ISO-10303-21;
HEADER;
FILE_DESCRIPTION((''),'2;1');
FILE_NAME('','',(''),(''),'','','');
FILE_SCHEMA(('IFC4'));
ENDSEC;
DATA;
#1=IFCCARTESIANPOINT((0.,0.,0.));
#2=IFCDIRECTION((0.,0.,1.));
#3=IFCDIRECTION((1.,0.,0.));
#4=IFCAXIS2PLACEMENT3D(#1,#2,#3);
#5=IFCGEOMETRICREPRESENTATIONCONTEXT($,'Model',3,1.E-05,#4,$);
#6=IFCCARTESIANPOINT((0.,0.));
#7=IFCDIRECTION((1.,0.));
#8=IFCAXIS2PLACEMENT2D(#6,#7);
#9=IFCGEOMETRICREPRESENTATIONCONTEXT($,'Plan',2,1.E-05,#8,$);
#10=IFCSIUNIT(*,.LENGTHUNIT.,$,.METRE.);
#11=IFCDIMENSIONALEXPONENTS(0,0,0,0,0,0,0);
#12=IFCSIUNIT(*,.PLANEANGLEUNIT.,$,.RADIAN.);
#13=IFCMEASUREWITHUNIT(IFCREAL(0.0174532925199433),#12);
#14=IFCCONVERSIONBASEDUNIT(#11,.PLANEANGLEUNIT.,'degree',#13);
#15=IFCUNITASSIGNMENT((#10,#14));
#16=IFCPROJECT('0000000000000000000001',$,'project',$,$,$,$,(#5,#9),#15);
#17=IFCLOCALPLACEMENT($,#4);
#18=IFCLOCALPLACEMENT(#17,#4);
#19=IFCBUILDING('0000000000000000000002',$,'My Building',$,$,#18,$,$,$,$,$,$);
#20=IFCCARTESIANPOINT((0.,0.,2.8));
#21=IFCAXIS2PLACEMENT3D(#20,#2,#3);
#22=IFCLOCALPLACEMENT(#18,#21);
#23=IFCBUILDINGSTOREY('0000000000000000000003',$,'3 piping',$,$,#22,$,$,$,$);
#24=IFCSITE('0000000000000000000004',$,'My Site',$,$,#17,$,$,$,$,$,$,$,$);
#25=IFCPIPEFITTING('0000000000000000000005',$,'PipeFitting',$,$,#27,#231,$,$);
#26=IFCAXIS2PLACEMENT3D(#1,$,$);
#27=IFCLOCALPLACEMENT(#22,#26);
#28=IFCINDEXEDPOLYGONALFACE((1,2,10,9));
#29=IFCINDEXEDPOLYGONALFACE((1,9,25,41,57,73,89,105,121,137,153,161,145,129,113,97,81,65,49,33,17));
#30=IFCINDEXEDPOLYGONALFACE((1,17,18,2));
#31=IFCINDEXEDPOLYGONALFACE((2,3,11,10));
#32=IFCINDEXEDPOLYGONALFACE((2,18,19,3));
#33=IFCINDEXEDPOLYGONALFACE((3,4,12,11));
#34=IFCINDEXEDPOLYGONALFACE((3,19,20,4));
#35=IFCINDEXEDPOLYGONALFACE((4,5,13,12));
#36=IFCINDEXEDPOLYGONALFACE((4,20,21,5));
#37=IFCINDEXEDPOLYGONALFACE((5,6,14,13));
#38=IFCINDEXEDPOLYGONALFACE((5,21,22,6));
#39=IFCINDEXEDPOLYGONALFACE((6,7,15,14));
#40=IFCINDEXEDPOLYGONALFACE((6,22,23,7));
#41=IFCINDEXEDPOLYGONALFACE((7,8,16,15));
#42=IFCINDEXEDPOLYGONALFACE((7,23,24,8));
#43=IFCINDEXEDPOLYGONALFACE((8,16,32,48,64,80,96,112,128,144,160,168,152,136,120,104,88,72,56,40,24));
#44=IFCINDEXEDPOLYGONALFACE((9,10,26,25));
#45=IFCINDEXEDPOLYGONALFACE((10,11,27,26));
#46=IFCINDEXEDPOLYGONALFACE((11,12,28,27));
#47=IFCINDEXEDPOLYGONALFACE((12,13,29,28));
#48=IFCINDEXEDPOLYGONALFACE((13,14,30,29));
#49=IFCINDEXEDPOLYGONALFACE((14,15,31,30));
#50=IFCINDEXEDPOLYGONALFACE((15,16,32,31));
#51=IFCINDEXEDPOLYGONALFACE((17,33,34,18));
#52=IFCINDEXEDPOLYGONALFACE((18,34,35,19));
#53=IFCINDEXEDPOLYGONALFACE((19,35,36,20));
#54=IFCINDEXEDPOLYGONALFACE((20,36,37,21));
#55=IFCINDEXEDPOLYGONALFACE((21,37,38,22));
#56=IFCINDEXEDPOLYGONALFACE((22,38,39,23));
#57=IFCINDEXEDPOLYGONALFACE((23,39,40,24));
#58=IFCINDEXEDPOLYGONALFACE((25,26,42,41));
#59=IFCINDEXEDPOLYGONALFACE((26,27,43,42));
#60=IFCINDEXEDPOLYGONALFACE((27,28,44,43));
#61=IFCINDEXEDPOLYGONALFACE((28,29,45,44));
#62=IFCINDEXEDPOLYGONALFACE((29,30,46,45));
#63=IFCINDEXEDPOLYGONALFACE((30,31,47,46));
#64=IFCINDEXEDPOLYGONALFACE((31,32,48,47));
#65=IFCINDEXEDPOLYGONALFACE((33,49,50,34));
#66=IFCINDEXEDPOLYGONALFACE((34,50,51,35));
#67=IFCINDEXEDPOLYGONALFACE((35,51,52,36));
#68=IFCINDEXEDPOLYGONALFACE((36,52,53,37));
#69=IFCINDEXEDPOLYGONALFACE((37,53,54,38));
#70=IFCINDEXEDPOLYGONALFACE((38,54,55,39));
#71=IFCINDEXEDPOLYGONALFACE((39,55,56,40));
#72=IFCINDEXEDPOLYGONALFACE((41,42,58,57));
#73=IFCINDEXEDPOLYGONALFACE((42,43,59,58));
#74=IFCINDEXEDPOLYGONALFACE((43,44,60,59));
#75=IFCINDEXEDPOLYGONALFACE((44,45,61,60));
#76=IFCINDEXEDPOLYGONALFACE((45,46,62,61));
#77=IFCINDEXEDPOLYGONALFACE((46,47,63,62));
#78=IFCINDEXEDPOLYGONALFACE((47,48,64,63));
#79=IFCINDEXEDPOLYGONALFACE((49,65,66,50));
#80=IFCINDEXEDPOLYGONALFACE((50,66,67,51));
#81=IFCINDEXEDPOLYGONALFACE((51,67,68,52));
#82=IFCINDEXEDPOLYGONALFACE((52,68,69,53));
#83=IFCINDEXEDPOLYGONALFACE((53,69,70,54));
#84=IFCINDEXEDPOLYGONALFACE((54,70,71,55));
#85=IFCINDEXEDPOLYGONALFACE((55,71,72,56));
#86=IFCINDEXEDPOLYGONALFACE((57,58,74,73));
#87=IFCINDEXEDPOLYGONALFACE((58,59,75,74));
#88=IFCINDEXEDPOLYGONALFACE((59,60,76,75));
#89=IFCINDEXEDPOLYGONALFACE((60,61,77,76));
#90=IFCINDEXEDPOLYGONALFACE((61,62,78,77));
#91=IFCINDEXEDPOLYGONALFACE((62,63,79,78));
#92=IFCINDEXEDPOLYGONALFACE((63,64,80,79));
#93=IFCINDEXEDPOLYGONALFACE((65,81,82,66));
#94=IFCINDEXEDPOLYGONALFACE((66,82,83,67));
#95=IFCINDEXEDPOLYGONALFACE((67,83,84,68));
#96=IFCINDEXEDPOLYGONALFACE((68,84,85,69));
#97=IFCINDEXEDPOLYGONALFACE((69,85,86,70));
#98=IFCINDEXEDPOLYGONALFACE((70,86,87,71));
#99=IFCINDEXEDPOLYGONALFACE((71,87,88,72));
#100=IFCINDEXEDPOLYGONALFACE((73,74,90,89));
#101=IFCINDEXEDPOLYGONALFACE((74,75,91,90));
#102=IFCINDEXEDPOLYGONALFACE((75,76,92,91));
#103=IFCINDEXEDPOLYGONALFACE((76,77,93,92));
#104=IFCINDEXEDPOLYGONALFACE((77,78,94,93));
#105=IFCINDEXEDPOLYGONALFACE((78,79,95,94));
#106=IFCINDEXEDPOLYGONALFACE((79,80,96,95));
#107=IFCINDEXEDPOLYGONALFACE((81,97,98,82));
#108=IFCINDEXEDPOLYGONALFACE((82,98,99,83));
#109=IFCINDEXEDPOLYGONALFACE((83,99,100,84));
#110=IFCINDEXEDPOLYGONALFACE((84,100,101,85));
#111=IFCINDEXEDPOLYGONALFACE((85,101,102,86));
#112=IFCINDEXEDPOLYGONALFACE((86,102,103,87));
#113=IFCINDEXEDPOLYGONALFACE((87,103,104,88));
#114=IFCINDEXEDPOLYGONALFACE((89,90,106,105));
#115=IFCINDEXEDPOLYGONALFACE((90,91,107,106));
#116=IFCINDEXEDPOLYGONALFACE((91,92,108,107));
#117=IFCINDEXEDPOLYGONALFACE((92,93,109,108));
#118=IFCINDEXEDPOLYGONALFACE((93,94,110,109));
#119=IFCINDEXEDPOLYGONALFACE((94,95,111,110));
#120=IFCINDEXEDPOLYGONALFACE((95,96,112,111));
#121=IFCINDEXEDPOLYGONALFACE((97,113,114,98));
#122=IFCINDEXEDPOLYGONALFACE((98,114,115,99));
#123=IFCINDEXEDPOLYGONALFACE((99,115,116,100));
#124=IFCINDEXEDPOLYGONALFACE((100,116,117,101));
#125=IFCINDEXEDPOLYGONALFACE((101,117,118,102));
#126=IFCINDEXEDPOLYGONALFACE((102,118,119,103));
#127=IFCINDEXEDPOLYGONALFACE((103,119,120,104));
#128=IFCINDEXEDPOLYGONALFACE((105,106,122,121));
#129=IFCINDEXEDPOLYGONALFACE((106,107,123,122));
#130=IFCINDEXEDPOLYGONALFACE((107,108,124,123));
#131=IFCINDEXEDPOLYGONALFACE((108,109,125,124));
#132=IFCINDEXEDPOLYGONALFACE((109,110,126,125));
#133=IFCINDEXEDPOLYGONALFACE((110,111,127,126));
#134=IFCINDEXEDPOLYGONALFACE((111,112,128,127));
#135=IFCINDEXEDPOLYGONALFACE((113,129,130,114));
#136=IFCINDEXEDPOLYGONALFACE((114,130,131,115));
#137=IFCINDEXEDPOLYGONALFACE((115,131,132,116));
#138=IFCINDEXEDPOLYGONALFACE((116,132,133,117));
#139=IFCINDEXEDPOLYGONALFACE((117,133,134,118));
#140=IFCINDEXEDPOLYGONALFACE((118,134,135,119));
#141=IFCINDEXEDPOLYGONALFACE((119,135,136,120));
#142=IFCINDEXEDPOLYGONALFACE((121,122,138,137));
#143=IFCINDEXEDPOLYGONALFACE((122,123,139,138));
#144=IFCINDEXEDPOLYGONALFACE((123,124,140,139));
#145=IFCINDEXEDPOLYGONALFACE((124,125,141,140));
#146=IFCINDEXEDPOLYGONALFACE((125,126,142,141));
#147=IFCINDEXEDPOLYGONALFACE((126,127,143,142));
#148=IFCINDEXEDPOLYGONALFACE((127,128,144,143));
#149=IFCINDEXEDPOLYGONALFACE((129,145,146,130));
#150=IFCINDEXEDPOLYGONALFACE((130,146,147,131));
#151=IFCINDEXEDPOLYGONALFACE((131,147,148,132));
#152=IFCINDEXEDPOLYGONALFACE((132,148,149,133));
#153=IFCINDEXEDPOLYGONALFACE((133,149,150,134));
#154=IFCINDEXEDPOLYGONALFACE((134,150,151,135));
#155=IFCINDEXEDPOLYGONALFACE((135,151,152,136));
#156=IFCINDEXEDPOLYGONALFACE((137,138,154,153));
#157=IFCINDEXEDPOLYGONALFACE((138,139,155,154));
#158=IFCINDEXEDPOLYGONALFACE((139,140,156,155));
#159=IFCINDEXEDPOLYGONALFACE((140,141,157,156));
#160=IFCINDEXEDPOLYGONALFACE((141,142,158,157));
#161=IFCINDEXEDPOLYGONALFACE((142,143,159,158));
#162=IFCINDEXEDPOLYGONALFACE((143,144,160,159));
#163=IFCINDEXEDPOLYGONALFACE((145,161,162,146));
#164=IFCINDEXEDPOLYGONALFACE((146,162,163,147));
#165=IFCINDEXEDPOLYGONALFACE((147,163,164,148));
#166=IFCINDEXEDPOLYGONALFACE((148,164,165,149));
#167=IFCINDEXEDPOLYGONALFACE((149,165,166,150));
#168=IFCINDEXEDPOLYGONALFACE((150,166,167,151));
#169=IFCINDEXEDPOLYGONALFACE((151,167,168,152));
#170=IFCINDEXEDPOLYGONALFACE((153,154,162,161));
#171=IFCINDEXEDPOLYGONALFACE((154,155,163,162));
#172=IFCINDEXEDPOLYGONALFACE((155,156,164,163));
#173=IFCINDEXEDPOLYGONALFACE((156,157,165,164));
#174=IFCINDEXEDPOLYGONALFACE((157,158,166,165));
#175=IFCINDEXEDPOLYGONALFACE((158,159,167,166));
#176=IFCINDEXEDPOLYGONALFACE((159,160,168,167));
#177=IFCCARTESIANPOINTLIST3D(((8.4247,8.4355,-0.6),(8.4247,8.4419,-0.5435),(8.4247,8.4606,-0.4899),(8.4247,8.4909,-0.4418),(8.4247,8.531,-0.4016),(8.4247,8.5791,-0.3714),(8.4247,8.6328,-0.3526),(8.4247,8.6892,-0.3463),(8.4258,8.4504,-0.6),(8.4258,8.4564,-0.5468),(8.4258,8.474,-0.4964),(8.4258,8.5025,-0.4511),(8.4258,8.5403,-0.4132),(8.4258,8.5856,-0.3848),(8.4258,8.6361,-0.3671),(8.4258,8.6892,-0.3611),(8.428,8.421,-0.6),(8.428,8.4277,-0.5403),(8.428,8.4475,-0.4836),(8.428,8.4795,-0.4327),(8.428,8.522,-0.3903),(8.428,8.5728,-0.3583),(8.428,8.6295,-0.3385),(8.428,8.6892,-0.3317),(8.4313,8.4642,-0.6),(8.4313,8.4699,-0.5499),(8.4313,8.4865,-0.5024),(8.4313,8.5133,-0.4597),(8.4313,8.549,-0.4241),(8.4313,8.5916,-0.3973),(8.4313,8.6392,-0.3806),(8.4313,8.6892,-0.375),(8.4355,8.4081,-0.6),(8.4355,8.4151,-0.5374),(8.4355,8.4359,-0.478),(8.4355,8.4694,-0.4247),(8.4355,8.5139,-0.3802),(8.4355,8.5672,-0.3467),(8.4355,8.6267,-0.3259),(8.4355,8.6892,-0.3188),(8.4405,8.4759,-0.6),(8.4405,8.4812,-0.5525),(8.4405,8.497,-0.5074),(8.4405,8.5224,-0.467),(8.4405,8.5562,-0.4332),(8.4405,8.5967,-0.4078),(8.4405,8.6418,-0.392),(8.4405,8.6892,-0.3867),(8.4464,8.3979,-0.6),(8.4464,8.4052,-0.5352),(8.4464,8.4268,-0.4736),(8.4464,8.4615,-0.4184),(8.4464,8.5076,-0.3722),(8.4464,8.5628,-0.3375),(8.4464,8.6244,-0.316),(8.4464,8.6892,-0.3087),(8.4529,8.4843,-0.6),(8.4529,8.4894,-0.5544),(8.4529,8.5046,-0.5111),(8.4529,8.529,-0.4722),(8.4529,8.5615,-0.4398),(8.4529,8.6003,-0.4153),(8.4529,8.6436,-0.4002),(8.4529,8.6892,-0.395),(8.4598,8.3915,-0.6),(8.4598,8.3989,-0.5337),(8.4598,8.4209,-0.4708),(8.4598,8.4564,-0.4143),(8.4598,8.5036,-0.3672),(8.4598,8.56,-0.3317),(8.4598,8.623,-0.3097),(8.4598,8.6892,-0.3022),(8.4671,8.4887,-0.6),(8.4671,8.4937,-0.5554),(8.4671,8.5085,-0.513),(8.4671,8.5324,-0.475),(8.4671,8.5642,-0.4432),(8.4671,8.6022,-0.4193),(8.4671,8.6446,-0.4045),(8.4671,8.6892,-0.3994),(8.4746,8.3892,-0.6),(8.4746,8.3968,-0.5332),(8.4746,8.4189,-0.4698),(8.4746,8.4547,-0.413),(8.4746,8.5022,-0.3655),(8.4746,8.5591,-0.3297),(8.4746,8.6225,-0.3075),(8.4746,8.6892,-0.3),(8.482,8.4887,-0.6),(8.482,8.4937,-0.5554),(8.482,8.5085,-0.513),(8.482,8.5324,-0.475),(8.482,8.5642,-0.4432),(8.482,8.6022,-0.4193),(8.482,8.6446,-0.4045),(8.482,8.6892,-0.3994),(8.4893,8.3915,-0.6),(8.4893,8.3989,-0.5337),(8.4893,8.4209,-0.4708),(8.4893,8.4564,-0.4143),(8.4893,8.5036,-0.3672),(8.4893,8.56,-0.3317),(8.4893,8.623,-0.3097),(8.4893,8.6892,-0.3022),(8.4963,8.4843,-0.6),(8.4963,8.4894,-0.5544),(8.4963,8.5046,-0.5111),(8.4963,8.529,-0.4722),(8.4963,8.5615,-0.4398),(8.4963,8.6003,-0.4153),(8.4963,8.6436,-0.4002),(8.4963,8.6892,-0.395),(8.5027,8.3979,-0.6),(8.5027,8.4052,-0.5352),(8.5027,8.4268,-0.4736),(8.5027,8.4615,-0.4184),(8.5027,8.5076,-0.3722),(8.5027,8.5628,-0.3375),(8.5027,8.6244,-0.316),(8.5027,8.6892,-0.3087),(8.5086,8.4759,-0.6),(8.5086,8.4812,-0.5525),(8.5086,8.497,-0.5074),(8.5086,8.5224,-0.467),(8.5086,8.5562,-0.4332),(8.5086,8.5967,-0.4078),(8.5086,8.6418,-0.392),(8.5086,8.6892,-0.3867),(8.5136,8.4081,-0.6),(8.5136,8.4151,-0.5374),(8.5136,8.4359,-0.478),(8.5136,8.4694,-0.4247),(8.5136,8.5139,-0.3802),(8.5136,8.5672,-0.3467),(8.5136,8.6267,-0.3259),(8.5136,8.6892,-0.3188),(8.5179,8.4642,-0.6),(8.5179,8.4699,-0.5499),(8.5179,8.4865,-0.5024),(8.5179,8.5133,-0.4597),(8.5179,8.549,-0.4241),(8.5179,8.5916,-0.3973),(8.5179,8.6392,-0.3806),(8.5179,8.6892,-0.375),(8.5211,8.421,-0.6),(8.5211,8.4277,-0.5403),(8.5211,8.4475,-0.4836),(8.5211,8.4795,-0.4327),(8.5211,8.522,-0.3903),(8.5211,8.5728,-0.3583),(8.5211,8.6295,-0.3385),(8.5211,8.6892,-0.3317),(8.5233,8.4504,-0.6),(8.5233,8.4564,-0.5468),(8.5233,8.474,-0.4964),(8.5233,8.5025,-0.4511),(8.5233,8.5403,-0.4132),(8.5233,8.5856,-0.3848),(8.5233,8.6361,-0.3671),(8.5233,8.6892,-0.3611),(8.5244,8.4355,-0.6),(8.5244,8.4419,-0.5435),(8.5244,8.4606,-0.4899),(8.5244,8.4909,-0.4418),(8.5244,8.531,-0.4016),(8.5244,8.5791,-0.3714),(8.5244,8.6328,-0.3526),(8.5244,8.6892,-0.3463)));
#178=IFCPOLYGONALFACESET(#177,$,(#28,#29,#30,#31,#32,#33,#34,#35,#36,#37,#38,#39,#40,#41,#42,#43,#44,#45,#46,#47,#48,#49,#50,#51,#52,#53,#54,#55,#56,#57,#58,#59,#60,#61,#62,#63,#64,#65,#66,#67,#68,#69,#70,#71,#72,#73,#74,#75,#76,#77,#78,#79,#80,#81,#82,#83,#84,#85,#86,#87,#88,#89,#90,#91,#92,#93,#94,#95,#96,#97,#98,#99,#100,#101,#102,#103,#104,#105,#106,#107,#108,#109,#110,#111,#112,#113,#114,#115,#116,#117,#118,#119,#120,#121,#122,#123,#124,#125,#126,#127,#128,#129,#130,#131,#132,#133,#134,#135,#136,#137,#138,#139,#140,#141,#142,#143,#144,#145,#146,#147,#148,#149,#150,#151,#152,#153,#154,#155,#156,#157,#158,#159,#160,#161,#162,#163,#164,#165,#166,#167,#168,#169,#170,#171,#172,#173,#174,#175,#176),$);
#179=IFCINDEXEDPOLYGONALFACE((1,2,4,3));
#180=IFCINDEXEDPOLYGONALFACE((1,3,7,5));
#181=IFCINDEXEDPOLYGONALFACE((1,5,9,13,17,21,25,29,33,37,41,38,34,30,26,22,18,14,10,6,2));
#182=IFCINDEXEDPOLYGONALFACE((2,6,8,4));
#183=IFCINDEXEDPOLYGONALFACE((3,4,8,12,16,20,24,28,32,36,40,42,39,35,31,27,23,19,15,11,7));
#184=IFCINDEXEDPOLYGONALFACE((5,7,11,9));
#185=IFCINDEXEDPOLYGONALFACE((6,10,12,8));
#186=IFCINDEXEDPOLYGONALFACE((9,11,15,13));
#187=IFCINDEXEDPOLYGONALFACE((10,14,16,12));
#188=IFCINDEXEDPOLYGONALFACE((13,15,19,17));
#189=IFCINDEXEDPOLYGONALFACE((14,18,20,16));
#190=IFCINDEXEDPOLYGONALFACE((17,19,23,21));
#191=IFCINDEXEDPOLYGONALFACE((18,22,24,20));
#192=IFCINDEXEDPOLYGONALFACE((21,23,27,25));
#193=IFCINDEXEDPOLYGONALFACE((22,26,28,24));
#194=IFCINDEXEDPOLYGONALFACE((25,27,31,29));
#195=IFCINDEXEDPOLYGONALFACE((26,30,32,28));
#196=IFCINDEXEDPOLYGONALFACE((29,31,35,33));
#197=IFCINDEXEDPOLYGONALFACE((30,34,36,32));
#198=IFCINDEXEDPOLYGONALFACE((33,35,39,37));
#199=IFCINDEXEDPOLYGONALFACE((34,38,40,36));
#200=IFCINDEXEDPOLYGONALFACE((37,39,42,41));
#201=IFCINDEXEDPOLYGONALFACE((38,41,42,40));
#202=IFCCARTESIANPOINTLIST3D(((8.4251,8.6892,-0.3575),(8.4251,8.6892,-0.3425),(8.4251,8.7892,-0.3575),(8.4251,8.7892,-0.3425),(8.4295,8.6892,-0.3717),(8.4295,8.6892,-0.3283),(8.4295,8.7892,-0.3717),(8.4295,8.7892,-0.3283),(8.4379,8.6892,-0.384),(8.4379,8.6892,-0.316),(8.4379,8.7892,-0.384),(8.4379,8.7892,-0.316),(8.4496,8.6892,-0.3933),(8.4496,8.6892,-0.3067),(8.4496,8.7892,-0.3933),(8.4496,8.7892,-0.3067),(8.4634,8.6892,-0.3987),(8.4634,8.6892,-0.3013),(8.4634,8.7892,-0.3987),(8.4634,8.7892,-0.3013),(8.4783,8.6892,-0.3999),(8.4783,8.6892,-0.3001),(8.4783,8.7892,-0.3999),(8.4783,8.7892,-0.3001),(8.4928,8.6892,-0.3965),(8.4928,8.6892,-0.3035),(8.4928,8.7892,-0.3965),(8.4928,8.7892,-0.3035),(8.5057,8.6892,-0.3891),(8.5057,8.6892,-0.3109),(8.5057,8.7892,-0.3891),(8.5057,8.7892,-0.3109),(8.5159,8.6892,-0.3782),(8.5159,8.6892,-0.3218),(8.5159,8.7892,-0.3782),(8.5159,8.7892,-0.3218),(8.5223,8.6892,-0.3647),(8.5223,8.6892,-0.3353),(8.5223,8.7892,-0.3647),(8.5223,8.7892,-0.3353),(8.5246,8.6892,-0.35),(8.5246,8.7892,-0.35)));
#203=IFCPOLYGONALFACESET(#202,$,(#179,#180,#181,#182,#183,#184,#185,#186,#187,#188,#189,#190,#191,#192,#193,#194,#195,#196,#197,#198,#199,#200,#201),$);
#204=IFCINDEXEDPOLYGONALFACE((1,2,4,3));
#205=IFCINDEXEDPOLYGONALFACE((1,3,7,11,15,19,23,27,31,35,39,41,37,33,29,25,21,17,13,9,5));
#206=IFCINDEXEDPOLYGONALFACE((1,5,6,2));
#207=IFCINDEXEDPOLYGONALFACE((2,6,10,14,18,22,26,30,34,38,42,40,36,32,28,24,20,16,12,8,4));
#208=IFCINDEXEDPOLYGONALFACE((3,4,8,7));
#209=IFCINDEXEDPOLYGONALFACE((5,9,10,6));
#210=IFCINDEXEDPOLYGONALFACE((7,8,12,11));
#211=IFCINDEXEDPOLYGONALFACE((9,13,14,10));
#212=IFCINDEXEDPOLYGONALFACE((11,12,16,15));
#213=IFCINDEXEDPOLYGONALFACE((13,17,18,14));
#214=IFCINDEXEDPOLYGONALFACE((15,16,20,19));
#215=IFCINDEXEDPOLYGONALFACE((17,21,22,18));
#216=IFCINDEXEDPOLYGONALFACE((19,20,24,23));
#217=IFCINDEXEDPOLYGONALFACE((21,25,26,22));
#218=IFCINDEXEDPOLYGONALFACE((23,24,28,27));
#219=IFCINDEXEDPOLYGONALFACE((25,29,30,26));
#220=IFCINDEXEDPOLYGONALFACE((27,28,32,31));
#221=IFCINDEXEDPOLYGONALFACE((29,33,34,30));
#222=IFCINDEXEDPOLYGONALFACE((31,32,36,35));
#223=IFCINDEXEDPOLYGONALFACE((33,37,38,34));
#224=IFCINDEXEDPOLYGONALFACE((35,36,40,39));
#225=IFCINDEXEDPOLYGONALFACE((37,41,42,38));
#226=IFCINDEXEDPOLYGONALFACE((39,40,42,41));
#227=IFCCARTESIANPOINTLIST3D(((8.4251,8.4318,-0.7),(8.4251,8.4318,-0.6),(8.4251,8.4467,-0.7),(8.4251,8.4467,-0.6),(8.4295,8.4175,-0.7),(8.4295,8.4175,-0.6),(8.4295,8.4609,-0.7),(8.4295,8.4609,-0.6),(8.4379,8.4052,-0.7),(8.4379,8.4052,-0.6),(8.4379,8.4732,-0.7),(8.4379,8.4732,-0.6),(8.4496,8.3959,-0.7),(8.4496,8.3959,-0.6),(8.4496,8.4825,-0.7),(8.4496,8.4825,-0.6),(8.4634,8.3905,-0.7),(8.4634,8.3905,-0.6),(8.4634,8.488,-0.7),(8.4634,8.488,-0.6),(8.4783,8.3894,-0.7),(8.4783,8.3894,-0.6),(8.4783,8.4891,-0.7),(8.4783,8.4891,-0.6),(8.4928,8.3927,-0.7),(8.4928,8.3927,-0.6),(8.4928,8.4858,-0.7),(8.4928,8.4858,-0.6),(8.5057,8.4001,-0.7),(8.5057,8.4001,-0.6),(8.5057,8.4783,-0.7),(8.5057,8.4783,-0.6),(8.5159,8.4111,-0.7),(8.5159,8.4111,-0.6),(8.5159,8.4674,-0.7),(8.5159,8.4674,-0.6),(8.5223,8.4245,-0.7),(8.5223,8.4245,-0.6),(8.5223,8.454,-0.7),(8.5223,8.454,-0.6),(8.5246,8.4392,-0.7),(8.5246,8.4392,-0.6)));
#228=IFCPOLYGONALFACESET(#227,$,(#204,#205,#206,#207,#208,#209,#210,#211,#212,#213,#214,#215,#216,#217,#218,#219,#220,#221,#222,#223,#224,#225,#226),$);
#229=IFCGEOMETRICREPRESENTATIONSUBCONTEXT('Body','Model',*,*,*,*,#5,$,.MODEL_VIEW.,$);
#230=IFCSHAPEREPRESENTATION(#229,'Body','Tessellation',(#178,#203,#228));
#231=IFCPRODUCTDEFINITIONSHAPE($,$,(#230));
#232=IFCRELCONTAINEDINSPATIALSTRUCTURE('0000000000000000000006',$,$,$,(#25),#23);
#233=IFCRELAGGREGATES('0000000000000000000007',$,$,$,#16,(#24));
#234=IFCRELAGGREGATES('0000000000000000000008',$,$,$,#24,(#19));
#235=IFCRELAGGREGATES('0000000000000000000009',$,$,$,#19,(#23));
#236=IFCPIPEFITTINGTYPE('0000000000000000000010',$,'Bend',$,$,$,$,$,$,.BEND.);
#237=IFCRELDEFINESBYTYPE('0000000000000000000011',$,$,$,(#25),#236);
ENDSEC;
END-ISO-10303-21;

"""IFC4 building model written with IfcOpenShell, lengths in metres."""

from ifc_helpers import new_model, entity, si_unit, converted_unit, frame, origin_with_axes, origin_2d_with_axis, place, context, subcontext, project, spatial, circle, extrude, source, transform, mapped, type_object, type_shapes, element, save


model = new_model("IFC4")

# Units and contexts
model_context = context("Model", 3, precision=1e-05, world=origin_with_axes())
plan_context = context("Plan", 2, precision=1e-05, world=origin_2d_with_axis())
body_context = subcontext(model_context, "Body", "Model", "MODEL_VIEW")
ifc_project = project(units=[si_unit("LENGTHUNIT", "METRE"), converted_unit("PLANEANGLEUNIT", "degree", entity("IfcReal", 0.0174532925199433), si_unit("PLANEANGLEUNIT", "RADIAN"), dimensions=[0, 0, 0, 0, 0, 0, 0])], contexts=[model_context, plan_context])

# Site, building, storey
site_placement = place(None, origin_with_axes())
site = spatial("IfcSite", under=ifc_project, at=site_placement, Name="My Site")
building_placement = place(site_placement, origin_with_axes())
building = spatial("IfcBuilding", under=site, at=building_placement, Name="My Building")
storey_placement = place(building_placement, frame((0.0, 0.0, 2.8), z_axis=(0.0, 0.0, 1.0), x_axis=(1.0, 0.0, 0.0)))
storey = spatial("IfcBuildingStorey", under=building, at=storey_placement, Name="3 piping")

# Pipe fitting
pipe_fitting_type_1 = type_object("IfcPipeFittingType", Name="Bend", PredefinedType="BEND")
shared_shape = source(origin_with_axes(), body_context, "Body", "SolidModel", [
    entity("IfcSweptDiskSolid", entity("IfcIndexedPolyCurve", entity("IfcCartesianPointList3D", [[0.0, 0.0, 0.1], [0.0, -0.0732, 0.2768], [0.0, -0.25, 0.35]]), [entity("IfcArcIndex", [1, 2, 3])]), 0.05),
    extrude(circle(Radius=0.05), origin_with_axes(), (0.0, 0.0, 1.0), 0.1),
    extrude(circle(Radius=0.05), frame((0.0, -0.25, 0.35), z_axis=(0.0, -1.0, 0.0), x_axis=(1.0, 0.0, 0.0)), (0.0, 0.0, 1.0), 0.1),
])
type_shapes(pipe_fitting_type_1, [shared_shape])
for number, where, z_axis, x_axis, name in (
    (1, (8.4746, 8.7892, -0.35), (0.0, -1.0, 0.0), (1.0, 0.0, 0.0), "PipeFitting"),
):
    element("IfcPipeFitting", number, at=place(storey_placement, frame(where, z_axis=z_axis, x_axis=x_axis)), inside=storey, type_object=pipe_fitting_type_1, Name=name, context=body_context, shape_type="MappedRepresentation", body=[
        mapped(shared_shape, transform((0.0, 0.0, 0.0), x_axis=(1.0, 0.0, 0.0), y_axis=(0.0, 1.0, 0.0), z_axis=(0.0, 0.0, 1.0), scale=1.0)),
    ])

save(model, "model.ifc")
